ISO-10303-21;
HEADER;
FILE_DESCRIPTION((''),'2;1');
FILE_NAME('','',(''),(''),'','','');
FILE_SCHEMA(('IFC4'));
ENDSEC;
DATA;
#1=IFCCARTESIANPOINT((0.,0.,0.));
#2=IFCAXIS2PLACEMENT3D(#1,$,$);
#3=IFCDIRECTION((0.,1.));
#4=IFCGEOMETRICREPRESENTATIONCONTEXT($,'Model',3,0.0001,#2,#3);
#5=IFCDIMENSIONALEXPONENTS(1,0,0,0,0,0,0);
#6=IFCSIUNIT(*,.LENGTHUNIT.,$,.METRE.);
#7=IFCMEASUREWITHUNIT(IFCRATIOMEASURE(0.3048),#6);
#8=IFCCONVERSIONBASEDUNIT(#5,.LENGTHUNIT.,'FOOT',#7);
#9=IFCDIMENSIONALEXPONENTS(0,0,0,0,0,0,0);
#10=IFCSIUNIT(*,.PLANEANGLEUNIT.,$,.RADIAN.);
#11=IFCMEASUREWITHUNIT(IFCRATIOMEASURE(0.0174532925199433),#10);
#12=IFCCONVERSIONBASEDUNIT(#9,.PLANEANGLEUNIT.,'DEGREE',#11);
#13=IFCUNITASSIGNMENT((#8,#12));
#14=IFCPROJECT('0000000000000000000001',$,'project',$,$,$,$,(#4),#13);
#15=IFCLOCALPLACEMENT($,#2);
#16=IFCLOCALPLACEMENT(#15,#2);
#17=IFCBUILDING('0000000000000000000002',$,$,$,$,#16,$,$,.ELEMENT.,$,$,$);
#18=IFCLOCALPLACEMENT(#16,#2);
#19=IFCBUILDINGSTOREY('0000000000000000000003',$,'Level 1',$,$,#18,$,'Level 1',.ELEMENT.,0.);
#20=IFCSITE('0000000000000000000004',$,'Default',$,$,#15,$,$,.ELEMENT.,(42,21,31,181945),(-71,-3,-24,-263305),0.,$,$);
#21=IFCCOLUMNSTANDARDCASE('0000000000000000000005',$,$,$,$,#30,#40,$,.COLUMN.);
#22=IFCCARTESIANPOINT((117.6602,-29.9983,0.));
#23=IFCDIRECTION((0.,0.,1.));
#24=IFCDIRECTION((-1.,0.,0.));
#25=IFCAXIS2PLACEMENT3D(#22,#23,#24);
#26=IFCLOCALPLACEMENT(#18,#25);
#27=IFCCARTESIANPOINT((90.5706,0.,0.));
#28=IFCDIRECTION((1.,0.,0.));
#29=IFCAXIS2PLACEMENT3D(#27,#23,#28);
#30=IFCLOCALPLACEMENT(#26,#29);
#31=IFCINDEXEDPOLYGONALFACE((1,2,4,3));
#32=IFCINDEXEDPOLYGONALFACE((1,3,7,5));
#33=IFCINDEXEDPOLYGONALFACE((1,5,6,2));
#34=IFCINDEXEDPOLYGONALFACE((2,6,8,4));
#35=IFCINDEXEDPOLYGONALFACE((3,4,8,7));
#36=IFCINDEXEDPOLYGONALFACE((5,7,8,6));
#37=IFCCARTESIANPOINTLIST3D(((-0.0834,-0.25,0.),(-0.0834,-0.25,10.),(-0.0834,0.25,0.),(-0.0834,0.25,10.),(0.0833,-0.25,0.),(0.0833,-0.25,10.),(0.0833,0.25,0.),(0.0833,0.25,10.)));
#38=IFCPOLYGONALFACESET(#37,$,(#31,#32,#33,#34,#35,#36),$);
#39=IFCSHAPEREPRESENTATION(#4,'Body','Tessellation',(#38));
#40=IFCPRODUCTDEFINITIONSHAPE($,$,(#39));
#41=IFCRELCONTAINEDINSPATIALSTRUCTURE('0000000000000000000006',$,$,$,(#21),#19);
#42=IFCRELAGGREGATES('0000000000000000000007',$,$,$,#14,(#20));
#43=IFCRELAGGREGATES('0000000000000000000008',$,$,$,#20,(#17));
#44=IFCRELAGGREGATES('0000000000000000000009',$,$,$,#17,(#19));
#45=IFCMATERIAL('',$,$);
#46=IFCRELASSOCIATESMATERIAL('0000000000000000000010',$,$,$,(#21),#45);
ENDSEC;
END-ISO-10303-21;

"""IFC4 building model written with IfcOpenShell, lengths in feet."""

from ifc_helpers import new_model, entity, si_unit, converted_unit, direction, frame, origin, place, context, project, spatial, rectangle, extrude, material, element, save


model = new_model("IFC4")

# Units and contexts
model_context = context("Model", 3, precision=0.0001, world=origin(), true_north=direction((0.0, 1.0)))
ifc_project = project(units=[converted_unit("LENGTHUNIT", "FOOT", entity("IfcRatioMeasure", 0.3048), si_unit("LENGTHUNIT", "METRE"), dimensions=[1, 0, 0, 0, 0, 0, 0]), converted_unit("PLANEANGLEUNIT", "DEGREE", entity("IfcRatioMeasure", 0.0174532925199433), si_unit("PLANEANGLEUNIT", "RADIAN"), dimensions=[0, 0, 0, 0, 0, 0, 0])], contexts=[model_context])

# Site, building, storey
site_placement = place(None, origin())
site = spatial("IfcSite", under=ifc_project, at=site_placement, Name="Default", CompositionType="ELEMENT", RefLatitude=(42, 21, 31, 181945), RefLongitude=(-71, -3, -24, -263305), RefElevation=0.0)
building_placement = place(site_placement, origin())
building = spatial("IfcBuilding", under=site, at=building_placement, CompositionType="ELEMENT")
storey_placement = place(building_placement, origin())
storey = spatial("IfcBuildingStorey", under=building, at=storey_placement, Name="Level 1", LongName="Level 1", CompositionType="ELEMENT", Elevation=0.0)

# Column
ifc_material_1 = material(Name="")
placement = place(storey_placement, frame((117.6602, -29.9983, 0.0), z_axis=(0.0, 0.0, 1.0), x_axis=(-1.0, 0.0, 0.0)))
for number, where, z_axis, x_axis in (
    (1, (90.5706, 0.0, 0.0), (0.0, 0.0, 1.0), (1.0, 0.0, 0.0)),
):
    element("IfcColumnStandardCase", number, at=place(placement, frame(where, z_axis=z_axis, x_axis=x_axis)), inside=storey, material=ifc_material_1, PredefinedType="COLUMN", context=model_context, shape_type="SweptSolid", body=[
        extrude(rectangle(XDim=0.1667, YDim=0.5), origin(), (0.0, 0.0, 1.0), 10.0),
    ])

save(model, "model.ifc")
